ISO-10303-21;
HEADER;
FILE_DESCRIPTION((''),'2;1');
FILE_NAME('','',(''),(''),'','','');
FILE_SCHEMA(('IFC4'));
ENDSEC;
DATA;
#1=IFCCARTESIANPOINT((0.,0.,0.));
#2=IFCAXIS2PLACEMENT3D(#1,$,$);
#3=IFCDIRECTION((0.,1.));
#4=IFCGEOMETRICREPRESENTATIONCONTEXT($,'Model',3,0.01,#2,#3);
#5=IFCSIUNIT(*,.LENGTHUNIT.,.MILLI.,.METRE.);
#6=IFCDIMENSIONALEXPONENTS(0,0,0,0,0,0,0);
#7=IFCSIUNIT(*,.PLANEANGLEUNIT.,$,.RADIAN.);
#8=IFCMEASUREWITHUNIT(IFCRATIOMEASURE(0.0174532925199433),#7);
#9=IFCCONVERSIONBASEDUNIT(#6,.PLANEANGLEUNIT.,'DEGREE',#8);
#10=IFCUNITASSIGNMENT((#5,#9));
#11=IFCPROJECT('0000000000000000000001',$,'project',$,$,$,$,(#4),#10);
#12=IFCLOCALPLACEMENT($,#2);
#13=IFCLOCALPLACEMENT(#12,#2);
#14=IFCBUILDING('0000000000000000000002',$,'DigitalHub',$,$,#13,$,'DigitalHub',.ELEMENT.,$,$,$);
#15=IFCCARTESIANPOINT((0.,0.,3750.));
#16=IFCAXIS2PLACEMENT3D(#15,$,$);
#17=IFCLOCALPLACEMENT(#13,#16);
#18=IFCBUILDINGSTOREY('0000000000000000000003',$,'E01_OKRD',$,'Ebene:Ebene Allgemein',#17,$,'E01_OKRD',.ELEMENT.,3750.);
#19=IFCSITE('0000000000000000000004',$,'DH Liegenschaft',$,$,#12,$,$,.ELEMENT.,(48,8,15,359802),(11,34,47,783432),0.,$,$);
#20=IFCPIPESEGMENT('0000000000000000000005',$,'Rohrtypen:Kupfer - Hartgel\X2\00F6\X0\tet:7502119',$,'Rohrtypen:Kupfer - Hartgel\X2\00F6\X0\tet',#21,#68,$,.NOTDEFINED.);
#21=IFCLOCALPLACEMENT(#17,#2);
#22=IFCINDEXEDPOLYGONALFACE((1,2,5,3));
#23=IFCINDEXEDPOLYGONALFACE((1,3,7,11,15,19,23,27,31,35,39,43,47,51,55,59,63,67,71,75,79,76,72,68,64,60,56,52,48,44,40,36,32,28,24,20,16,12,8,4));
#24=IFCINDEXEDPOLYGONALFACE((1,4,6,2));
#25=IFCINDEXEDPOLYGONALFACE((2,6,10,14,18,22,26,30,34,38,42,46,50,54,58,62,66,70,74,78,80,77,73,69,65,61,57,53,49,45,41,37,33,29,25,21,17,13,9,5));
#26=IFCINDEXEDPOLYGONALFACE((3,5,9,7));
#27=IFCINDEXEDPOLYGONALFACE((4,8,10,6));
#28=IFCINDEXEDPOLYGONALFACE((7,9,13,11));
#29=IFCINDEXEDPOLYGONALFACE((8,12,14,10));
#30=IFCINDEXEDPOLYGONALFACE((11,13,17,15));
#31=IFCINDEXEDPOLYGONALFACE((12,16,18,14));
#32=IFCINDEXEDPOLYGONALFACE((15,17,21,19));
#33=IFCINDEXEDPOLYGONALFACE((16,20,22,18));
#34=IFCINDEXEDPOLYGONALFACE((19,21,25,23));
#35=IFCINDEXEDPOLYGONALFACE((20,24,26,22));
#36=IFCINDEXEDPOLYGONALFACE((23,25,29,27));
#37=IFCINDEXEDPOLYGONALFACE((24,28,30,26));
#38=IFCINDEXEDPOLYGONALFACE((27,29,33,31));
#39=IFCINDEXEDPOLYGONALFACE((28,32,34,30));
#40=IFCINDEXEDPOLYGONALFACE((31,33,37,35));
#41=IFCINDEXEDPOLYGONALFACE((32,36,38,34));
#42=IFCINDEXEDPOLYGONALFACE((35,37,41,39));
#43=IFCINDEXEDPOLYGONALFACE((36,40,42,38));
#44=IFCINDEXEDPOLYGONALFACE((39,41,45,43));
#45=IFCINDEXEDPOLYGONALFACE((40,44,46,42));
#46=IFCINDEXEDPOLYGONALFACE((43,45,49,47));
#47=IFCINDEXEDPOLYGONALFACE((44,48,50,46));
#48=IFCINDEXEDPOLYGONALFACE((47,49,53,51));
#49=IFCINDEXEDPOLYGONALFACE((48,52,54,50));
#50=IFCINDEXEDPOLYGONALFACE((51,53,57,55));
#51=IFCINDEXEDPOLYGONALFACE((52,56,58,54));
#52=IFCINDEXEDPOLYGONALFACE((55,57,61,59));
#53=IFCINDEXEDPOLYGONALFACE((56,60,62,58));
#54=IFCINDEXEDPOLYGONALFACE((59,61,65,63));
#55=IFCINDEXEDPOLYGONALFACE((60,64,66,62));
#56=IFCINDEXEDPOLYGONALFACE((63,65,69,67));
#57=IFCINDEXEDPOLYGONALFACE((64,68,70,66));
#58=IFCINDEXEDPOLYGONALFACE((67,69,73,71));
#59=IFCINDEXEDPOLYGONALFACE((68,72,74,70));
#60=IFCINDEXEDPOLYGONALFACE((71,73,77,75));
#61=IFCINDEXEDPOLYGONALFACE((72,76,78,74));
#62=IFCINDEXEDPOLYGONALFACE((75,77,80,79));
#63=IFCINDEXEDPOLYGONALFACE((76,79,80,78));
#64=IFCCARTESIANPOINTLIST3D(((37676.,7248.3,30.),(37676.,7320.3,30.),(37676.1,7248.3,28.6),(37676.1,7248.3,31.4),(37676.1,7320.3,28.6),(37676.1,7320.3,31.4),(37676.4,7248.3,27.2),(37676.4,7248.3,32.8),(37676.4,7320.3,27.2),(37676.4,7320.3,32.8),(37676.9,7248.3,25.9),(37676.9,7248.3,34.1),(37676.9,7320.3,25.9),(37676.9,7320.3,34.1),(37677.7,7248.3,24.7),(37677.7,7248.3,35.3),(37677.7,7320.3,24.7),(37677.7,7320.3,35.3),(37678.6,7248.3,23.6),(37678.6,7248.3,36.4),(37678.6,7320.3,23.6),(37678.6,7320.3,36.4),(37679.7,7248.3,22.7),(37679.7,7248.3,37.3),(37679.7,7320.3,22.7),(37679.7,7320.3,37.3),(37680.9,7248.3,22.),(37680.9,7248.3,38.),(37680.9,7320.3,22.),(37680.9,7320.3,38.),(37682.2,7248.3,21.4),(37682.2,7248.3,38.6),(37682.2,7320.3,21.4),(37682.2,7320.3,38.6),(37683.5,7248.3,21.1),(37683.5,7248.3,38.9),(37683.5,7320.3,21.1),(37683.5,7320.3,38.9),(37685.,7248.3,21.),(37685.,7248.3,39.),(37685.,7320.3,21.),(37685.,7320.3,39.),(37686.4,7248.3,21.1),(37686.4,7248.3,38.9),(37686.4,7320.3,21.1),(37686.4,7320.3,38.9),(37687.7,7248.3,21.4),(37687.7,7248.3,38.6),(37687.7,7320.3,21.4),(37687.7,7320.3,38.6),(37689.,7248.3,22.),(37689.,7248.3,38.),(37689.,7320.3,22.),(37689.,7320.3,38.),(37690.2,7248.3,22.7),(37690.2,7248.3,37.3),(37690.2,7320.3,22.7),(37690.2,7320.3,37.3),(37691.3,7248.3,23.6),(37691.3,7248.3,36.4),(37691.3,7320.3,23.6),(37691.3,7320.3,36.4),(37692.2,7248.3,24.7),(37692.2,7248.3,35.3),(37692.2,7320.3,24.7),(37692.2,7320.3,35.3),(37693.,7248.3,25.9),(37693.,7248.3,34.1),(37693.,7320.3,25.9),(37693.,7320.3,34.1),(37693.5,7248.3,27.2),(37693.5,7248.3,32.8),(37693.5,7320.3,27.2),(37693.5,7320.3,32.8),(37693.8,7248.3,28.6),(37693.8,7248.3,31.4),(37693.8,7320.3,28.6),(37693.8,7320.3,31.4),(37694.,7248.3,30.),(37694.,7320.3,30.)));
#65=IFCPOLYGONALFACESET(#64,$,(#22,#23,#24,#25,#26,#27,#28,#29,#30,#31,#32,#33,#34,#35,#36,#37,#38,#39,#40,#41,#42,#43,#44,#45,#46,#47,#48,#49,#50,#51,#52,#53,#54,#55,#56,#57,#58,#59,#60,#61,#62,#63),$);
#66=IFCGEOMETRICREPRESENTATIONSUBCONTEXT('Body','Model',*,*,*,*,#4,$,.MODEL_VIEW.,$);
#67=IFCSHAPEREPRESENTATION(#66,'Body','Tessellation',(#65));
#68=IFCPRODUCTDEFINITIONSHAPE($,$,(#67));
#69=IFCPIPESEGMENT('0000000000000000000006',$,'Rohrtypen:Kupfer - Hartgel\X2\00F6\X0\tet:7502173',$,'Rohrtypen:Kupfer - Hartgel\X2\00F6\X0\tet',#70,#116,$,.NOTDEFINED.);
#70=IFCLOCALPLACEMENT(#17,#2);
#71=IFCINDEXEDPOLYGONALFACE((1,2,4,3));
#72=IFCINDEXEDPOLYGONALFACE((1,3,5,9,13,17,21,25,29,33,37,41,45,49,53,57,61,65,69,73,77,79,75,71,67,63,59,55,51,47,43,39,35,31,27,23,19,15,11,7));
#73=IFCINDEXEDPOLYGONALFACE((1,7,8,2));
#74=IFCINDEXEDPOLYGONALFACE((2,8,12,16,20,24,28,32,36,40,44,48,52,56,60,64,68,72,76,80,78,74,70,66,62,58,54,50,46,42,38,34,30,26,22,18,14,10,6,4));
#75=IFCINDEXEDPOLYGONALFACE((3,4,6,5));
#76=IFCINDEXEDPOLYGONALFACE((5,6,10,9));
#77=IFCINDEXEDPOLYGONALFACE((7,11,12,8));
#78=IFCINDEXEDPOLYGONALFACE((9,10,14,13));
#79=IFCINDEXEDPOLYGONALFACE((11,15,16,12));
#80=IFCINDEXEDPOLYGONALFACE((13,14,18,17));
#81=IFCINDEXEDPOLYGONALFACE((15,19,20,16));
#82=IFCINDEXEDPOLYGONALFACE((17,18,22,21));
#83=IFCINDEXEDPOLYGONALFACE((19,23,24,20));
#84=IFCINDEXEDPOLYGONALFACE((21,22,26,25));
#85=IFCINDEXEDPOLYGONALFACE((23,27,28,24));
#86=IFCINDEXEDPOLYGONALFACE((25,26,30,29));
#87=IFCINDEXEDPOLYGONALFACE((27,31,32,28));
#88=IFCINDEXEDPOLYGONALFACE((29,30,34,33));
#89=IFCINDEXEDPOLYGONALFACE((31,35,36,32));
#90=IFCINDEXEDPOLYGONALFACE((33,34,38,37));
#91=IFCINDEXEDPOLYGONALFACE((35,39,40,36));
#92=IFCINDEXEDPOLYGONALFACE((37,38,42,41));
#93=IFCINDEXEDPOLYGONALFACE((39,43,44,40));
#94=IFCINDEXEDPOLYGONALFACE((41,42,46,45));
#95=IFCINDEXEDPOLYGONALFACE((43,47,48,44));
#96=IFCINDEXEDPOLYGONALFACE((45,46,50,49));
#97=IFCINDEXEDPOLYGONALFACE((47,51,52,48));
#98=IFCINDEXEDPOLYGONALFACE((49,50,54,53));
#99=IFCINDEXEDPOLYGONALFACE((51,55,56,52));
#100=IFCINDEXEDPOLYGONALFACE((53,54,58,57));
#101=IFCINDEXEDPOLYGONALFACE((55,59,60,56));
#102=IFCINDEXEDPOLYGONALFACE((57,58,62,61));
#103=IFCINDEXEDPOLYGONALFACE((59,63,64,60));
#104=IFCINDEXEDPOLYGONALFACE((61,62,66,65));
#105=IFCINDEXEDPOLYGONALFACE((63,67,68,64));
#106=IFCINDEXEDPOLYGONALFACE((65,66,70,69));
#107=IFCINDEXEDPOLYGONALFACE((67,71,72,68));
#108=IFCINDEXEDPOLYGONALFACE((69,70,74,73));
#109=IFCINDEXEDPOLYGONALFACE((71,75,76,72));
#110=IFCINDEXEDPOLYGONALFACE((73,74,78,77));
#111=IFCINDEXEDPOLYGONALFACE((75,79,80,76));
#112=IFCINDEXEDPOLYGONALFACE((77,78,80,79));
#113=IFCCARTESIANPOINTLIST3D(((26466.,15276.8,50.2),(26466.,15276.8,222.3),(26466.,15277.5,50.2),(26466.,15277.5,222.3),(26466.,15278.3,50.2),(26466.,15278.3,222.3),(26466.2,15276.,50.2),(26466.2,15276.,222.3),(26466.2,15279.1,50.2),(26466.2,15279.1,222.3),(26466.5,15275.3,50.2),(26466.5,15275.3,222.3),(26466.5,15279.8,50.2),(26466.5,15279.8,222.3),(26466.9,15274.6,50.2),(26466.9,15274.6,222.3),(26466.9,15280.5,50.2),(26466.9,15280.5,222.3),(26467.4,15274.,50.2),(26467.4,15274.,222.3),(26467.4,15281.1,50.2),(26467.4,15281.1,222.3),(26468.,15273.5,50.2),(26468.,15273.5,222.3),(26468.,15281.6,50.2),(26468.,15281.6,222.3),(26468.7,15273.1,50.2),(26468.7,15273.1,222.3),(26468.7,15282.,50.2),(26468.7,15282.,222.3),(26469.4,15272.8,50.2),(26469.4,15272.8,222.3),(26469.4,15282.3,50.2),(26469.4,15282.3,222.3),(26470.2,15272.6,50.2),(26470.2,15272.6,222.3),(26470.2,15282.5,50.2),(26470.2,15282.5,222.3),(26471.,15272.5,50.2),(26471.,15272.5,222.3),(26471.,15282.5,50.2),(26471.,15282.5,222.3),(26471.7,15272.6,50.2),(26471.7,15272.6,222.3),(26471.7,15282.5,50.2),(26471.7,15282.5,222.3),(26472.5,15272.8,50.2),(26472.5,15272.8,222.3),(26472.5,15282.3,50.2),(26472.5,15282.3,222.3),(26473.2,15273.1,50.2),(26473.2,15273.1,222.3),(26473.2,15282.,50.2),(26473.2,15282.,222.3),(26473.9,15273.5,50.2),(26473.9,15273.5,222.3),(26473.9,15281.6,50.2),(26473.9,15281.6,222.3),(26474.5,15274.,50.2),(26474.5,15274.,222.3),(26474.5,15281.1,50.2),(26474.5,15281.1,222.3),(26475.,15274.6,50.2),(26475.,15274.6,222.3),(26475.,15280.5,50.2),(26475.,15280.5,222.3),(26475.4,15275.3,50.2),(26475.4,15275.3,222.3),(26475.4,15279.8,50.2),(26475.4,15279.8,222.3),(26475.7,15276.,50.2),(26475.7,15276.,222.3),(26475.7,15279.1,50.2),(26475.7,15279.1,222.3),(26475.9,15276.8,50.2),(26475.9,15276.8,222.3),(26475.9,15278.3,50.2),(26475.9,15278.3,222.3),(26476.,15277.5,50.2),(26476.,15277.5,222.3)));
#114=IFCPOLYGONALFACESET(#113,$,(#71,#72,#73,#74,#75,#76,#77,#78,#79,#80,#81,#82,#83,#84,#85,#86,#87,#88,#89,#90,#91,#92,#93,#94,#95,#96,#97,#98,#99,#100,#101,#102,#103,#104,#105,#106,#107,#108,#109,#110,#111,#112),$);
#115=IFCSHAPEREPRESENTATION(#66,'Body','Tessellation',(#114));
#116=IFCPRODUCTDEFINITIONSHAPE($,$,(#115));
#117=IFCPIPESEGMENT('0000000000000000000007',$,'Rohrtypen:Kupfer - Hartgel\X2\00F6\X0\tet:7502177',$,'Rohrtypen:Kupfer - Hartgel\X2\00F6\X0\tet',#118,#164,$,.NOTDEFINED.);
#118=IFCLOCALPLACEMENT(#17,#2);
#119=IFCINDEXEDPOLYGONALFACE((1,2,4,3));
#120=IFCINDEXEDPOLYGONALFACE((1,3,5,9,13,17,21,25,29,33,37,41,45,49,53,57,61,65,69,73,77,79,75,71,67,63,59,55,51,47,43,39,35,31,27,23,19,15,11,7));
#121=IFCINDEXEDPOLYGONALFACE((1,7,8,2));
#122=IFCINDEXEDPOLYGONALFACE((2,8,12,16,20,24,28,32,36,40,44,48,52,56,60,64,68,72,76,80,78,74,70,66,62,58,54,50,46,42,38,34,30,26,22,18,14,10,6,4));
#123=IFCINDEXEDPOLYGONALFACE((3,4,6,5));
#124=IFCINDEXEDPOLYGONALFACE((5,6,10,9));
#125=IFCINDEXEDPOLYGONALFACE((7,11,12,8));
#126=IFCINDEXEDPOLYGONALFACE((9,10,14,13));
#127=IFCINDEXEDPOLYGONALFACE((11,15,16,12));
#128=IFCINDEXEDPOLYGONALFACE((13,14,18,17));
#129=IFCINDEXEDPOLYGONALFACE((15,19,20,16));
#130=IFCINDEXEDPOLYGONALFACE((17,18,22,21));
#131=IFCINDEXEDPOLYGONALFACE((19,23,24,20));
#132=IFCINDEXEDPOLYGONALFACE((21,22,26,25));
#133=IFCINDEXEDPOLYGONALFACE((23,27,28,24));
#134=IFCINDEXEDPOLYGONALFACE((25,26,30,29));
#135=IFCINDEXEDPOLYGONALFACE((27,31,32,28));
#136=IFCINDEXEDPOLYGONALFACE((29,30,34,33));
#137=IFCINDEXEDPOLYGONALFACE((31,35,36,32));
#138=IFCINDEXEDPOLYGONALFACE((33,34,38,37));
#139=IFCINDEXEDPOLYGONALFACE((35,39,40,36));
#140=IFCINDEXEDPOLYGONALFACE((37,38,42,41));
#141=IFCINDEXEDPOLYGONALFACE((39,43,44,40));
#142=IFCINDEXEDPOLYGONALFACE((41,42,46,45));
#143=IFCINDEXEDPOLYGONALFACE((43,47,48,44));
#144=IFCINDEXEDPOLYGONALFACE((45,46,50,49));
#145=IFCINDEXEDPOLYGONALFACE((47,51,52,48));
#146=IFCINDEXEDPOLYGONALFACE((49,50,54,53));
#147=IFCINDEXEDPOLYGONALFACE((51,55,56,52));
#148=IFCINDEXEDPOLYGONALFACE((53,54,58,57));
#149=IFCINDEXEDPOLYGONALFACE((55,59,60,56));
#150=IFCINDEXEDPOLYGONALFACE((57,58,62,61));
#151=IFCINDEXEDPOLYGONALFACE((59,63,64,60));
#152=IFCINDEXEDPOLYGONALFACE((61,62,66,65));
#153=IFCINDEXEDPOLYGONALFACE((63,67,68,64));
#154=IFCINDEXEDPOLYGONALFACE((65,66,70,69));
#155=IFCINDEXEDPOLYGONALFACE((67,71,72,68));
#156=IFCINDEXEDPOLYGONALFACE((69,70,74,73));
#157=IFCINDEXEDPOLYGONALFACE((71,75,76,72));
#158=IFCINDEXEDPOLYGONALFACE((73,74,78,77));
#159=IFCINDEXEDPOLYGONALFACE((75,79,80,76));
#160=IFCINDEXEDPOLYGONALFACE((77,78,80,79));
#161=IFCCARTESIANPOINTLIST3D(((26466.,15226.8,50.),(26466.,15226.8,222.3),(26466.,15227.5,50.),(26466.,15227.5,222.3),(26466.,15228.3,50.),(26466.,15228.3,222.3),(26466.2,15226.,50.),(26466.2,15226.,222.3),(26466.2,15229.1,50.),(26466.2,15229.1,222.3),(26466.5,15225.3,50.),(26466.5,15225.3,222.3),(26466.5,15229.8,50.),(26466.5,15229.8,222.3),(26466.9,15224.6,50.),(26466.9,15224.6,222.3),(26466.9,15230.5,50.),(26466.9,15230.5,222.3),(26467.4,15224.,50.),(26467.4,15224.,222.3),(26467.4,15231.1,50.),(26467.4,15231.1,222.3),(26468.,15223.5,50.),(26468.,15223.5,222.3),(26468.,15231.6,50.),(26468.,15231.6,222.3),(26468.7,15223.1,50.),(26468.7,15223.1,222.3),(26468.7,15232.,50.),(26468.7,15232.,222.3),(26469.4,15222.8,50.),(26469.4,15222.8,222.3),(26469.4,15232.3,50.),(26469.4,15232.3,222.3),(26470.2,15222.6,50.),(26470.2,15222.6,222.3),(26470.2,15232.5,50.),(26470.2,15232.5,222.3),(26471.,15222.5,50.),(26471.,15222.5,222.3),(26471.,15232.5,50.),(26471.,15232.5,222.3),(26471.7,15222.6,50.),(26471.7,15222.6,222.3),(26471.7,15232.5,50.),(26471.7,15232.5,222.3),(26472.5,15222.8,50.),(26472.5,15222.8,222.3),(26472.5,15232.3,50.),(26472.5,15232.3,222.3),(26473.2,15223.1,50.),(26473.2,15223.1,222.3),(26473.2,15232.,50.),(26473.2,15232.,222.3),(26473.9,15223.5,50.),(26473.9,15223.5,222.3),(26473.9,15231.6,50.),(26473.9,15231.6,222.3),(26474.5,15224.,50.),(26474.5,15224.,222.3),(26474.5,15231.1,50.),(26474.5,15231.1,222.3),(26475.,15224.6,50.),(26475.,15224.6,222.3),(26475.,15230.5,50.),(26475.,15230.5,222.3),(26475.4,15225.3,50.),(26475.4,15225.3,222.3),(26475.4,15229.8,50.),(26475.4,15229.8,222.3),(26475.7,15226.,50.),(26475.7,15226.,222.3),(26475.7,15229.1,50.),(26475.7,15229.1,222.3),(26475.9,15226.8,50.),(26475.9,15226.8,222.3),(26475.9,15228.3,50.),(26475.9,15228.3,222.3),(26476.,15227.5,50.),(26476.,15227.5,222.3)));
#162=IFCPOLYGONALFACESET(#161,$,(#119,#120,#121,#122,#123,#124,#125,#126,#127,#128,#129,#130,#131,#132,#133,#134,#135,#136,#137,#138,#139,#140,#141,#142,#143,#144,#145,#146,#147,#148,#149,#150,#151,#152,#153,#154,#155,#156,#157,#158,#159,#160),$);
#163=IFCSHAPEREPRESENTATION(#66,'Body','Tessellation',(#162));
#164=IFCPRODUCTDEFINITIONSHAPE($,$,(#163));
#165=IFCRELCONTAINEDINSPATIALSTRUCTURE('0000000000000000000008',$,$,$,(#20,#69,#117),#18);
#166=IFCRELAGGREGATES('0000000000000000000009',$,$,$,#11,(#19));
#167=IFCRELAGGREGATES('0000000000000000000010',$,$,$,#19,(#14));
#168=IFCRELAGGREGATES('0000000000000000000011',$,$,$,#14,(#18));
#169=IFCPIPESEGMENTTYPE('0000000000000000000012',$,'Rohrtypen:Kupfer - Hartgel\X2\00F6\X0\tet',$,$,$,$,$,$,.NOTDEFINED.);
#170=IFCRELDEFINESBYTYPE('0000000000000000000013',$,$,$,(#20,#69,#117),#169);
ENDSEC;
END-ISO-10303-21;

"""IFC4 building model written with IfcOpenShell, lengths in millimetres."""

from ifc_helpers import new_model, entity, si_unit, converted_unit, direction, frame, origin, place, context, subcontext, project, spatial, indexed_curve, outline, extrude, type_object, element, save


model = new_model("IFC4")

# Units and contexts
model_context = context("Model", 3, precision=0.01, world=origin(), true_north=direction((0.0, 1.0)))
body_context = subcontext(model_context, "Body", "Model", "MODEL_VIEW")
ifc_project = project(units=[si_unit("LENGTHUNIT", "METRE", prefix="MILLI"), converted_unit("PLANEANGLEUNIT", "DEGREE", entity("IfcRatioMeasure", 0.0174532925199433), si_unit("PLANEANGLEUNIT", "RADIAN"), dimensions=[0, 0, 0, 0, 0, 0, 0])], contexts=[model_context])

# Site, building, storey
site_placement = place(None, origin())
site = spatial("IfcSite", under=ifc_project, at=site_placement, Name="DH Liegenschaft", CompositionType="ELEMENT", RefLatitude=(48, 8, 15, 359802), RefLongitude=(11, 34, 47, 783432), RefElevation=0.0)
building_placement = place(site_placement, origin())
building = spatial("IfcBuilding", under=site, at=building_placement, Name="DigitalHub", LongName="DigitalHub", CompositionType="ELEMENT")
storey_placement = place(building_placement, frame((0.0, 0.0, 3750.0)))
storey = spatial("IfcBuildingStorey", under=building, at=storey_placement, Name="E01_OKRD", ObjectType="Ebene:Ebene Allgemein", LongName="E01_OKRD", CompositionType="ELEMENT", Elevation=3750.0)

# Pipe segments
pipe_segment_type = type_object("IfcPipeSegmentType", Name="Rohrtypen:Kupfer - Hartgelötet", PredefinedType="NOTDEFINED")
pipe_segment_1_placement = place(storey_placement, frame((37674.4, 7248.3, 19.4)))
element("IfcPipeSegment", 1, at=pipe_segment_1_placement, inside=storey, type_object=pipe_segment_type, Name="Rohrtypen:Kupfer - Hartgelötet:7502119", ObjectType="Rohrtypen:Kupfer - Hartgelötet", PredefinedType="NOTDEFINED", context=body_context, shape_type="SweptSolid", body=[
    extrude(outline(indexed_curve([(9.0, 0.0), (8.9, 1.4), (8.6, 2.8), (8.0, 4.1), (7.3, 5.3), (6.4, 6.4), (5.3, 7.3), (4.1, 8.0), (2.8, 8.6), (1.4, 8.9), (0.0, 9.0), (-1.4, 8.9), (-2.8, 8.6), (-4.1, 8.0), (-5.3, 7.3), (-6.4, 6.4), (-7.3, 5.3), (-8.0, 4.1), (-8.6, 2.8), (-8.9, 1.4), (-9.0, 0.0), (-8.9, -1.4), (-8.6, -2.8), (-8.0, -4.1), (-7.3, -5.3), (-6.4, -6.4), (-5.3, -7.3), (-4.1, -8.0), (-2.8, -8.6), (-1.4, -8.9), (0.0, -9.0), (1.4, -8.9), (2.8, -8.6), (4.1, -8.0), (5.3, -7.3), (6.4, -6.4), (7.3, -5.3), (8.0, -4.1), (8.6, -2.8), (8.9, -1.4), (9.0, 0.0)], self_intersect=False)), frame((10.6, 0.0, 10.6), z_axis=(0.0, 1.0, 0.0), x_axis=(1.0, 0.0, 0.0)), (0.0, 0.0, 1.0), 71.9),
])
pipe_segment_2_placement = place(storey_placement, frame((26464.4, 15270.9, 50.2)))
element("IfcPipeSegment", 2, at=pipe_segment_2_placement, inside=storey, type_object=pipe_segment_type, Name="Rohrtypen:Kupfer - Hartgelötet:7502173", ObjectType="Rohrtypen:Kupfer - Hartgelötet", PredefinedType="NOTDEFINED", context=body_context, shape_type="SweptSolid", body=[
    extrude(outline(indexed_curve([(5.0, 0.0), (4.9, 0.8), (4.8, 1.5), (4.5, 2.3), (4.0, 2.9), (3.5, 3.5), (2.9, 4.0), (2.3, 4.5), (1.5, 4.8), (0.8, 4.9), (0.0, 5.0), (-0.8, 4.9), (-1.5, 4.8), (-2.3, 4.5), (-2.9, 4.0), (-3.5, 3.5), (-4.0, 2.9), (-4.5, 2.3), (-4.8, 1.5), (-4.9, 0.8), (-5.0, 0.0), (-4.9, -0.8), (-4.8, -1.5), (-4.5, -2.3), (-4.0, -2.9), (-3.5, -3.5), (-2.9, -4.0), (-2.3, -4.5), (-1.5, -4.8), (-0.8, -4.9), (0.0, -5.0), (0.8, -4.9), (1.5, -4.8), (2.3, -4.5), (2.9, -4.0), (3.5, -3.5), (4.0, -2.9), (4.5, -2.3), (4.8, -1.5), (4.9, -0.8), (5.0, 0.0)], self_intersect=False)), frame((6.6, 6.6, 0.0)), (0.0, 0.0, 1.0), 172.1),
])
pipe_segment_3_placement = place(storey_placement, frame((26464.4, 15220.9, 50.0)))
element("IfcPipeSegment", 3, at=pipe_segment_3_placement, inside=storey, type_object=pipe_segment_type, Name="Rohrtypen:Kupfer - Hartgelötet:7502177", ObjectType="Rohrtypen:Kupfer - Hartgelötet", PredefinedType="NOTDEFINED", context=body_context, shape_type="SweptSolid", body=[
    extrude(outline(indexed_curve([(5.0, 0.0), (4.9, 0.8), (4.8, 1.5), (4.5, 2.3), (4.0, 2.9), (3.5, 3.5), (2.9, 4.0), (2.3, 4.5), (1.5, 4.8), (0.8, 4.9), (0.0, 5.0), (-0.8, 4.9), (-1.5, 4.8), (-2.3, 4.5), (-2.9, 4.0), (-3.5, 3.5), (-4.0, 2.9), (-4.5, 2.3), (-4.8, 1.5), (-4.9, 0.8), (-5.0, 0.0), (-4.9, -0.8), (-4.8, -1.5), (-4.5, -2.3), (-4.0, -2.9), (-3.5, -3.5), (-2.9, -4.0), (-2.3, -4.5), (-1.5, -4.8), (-0.8, -4.9), (0.0, -5.0), (0.8, -4.9), (1.5, -4.8), (2.3, -4.5), (2.9, -4.0), (3.5, -3.5), (4.0, -2.9), (4.5, -2.3), (4.8, -1.5), (4.9, -0.8), (5.0, 0.0)], self_intersect=False)), frame((6.6, 6.6, 0.0)), (0.0, 0.0, 1.0), 172.3),
])

save(model, "model.ifc")
